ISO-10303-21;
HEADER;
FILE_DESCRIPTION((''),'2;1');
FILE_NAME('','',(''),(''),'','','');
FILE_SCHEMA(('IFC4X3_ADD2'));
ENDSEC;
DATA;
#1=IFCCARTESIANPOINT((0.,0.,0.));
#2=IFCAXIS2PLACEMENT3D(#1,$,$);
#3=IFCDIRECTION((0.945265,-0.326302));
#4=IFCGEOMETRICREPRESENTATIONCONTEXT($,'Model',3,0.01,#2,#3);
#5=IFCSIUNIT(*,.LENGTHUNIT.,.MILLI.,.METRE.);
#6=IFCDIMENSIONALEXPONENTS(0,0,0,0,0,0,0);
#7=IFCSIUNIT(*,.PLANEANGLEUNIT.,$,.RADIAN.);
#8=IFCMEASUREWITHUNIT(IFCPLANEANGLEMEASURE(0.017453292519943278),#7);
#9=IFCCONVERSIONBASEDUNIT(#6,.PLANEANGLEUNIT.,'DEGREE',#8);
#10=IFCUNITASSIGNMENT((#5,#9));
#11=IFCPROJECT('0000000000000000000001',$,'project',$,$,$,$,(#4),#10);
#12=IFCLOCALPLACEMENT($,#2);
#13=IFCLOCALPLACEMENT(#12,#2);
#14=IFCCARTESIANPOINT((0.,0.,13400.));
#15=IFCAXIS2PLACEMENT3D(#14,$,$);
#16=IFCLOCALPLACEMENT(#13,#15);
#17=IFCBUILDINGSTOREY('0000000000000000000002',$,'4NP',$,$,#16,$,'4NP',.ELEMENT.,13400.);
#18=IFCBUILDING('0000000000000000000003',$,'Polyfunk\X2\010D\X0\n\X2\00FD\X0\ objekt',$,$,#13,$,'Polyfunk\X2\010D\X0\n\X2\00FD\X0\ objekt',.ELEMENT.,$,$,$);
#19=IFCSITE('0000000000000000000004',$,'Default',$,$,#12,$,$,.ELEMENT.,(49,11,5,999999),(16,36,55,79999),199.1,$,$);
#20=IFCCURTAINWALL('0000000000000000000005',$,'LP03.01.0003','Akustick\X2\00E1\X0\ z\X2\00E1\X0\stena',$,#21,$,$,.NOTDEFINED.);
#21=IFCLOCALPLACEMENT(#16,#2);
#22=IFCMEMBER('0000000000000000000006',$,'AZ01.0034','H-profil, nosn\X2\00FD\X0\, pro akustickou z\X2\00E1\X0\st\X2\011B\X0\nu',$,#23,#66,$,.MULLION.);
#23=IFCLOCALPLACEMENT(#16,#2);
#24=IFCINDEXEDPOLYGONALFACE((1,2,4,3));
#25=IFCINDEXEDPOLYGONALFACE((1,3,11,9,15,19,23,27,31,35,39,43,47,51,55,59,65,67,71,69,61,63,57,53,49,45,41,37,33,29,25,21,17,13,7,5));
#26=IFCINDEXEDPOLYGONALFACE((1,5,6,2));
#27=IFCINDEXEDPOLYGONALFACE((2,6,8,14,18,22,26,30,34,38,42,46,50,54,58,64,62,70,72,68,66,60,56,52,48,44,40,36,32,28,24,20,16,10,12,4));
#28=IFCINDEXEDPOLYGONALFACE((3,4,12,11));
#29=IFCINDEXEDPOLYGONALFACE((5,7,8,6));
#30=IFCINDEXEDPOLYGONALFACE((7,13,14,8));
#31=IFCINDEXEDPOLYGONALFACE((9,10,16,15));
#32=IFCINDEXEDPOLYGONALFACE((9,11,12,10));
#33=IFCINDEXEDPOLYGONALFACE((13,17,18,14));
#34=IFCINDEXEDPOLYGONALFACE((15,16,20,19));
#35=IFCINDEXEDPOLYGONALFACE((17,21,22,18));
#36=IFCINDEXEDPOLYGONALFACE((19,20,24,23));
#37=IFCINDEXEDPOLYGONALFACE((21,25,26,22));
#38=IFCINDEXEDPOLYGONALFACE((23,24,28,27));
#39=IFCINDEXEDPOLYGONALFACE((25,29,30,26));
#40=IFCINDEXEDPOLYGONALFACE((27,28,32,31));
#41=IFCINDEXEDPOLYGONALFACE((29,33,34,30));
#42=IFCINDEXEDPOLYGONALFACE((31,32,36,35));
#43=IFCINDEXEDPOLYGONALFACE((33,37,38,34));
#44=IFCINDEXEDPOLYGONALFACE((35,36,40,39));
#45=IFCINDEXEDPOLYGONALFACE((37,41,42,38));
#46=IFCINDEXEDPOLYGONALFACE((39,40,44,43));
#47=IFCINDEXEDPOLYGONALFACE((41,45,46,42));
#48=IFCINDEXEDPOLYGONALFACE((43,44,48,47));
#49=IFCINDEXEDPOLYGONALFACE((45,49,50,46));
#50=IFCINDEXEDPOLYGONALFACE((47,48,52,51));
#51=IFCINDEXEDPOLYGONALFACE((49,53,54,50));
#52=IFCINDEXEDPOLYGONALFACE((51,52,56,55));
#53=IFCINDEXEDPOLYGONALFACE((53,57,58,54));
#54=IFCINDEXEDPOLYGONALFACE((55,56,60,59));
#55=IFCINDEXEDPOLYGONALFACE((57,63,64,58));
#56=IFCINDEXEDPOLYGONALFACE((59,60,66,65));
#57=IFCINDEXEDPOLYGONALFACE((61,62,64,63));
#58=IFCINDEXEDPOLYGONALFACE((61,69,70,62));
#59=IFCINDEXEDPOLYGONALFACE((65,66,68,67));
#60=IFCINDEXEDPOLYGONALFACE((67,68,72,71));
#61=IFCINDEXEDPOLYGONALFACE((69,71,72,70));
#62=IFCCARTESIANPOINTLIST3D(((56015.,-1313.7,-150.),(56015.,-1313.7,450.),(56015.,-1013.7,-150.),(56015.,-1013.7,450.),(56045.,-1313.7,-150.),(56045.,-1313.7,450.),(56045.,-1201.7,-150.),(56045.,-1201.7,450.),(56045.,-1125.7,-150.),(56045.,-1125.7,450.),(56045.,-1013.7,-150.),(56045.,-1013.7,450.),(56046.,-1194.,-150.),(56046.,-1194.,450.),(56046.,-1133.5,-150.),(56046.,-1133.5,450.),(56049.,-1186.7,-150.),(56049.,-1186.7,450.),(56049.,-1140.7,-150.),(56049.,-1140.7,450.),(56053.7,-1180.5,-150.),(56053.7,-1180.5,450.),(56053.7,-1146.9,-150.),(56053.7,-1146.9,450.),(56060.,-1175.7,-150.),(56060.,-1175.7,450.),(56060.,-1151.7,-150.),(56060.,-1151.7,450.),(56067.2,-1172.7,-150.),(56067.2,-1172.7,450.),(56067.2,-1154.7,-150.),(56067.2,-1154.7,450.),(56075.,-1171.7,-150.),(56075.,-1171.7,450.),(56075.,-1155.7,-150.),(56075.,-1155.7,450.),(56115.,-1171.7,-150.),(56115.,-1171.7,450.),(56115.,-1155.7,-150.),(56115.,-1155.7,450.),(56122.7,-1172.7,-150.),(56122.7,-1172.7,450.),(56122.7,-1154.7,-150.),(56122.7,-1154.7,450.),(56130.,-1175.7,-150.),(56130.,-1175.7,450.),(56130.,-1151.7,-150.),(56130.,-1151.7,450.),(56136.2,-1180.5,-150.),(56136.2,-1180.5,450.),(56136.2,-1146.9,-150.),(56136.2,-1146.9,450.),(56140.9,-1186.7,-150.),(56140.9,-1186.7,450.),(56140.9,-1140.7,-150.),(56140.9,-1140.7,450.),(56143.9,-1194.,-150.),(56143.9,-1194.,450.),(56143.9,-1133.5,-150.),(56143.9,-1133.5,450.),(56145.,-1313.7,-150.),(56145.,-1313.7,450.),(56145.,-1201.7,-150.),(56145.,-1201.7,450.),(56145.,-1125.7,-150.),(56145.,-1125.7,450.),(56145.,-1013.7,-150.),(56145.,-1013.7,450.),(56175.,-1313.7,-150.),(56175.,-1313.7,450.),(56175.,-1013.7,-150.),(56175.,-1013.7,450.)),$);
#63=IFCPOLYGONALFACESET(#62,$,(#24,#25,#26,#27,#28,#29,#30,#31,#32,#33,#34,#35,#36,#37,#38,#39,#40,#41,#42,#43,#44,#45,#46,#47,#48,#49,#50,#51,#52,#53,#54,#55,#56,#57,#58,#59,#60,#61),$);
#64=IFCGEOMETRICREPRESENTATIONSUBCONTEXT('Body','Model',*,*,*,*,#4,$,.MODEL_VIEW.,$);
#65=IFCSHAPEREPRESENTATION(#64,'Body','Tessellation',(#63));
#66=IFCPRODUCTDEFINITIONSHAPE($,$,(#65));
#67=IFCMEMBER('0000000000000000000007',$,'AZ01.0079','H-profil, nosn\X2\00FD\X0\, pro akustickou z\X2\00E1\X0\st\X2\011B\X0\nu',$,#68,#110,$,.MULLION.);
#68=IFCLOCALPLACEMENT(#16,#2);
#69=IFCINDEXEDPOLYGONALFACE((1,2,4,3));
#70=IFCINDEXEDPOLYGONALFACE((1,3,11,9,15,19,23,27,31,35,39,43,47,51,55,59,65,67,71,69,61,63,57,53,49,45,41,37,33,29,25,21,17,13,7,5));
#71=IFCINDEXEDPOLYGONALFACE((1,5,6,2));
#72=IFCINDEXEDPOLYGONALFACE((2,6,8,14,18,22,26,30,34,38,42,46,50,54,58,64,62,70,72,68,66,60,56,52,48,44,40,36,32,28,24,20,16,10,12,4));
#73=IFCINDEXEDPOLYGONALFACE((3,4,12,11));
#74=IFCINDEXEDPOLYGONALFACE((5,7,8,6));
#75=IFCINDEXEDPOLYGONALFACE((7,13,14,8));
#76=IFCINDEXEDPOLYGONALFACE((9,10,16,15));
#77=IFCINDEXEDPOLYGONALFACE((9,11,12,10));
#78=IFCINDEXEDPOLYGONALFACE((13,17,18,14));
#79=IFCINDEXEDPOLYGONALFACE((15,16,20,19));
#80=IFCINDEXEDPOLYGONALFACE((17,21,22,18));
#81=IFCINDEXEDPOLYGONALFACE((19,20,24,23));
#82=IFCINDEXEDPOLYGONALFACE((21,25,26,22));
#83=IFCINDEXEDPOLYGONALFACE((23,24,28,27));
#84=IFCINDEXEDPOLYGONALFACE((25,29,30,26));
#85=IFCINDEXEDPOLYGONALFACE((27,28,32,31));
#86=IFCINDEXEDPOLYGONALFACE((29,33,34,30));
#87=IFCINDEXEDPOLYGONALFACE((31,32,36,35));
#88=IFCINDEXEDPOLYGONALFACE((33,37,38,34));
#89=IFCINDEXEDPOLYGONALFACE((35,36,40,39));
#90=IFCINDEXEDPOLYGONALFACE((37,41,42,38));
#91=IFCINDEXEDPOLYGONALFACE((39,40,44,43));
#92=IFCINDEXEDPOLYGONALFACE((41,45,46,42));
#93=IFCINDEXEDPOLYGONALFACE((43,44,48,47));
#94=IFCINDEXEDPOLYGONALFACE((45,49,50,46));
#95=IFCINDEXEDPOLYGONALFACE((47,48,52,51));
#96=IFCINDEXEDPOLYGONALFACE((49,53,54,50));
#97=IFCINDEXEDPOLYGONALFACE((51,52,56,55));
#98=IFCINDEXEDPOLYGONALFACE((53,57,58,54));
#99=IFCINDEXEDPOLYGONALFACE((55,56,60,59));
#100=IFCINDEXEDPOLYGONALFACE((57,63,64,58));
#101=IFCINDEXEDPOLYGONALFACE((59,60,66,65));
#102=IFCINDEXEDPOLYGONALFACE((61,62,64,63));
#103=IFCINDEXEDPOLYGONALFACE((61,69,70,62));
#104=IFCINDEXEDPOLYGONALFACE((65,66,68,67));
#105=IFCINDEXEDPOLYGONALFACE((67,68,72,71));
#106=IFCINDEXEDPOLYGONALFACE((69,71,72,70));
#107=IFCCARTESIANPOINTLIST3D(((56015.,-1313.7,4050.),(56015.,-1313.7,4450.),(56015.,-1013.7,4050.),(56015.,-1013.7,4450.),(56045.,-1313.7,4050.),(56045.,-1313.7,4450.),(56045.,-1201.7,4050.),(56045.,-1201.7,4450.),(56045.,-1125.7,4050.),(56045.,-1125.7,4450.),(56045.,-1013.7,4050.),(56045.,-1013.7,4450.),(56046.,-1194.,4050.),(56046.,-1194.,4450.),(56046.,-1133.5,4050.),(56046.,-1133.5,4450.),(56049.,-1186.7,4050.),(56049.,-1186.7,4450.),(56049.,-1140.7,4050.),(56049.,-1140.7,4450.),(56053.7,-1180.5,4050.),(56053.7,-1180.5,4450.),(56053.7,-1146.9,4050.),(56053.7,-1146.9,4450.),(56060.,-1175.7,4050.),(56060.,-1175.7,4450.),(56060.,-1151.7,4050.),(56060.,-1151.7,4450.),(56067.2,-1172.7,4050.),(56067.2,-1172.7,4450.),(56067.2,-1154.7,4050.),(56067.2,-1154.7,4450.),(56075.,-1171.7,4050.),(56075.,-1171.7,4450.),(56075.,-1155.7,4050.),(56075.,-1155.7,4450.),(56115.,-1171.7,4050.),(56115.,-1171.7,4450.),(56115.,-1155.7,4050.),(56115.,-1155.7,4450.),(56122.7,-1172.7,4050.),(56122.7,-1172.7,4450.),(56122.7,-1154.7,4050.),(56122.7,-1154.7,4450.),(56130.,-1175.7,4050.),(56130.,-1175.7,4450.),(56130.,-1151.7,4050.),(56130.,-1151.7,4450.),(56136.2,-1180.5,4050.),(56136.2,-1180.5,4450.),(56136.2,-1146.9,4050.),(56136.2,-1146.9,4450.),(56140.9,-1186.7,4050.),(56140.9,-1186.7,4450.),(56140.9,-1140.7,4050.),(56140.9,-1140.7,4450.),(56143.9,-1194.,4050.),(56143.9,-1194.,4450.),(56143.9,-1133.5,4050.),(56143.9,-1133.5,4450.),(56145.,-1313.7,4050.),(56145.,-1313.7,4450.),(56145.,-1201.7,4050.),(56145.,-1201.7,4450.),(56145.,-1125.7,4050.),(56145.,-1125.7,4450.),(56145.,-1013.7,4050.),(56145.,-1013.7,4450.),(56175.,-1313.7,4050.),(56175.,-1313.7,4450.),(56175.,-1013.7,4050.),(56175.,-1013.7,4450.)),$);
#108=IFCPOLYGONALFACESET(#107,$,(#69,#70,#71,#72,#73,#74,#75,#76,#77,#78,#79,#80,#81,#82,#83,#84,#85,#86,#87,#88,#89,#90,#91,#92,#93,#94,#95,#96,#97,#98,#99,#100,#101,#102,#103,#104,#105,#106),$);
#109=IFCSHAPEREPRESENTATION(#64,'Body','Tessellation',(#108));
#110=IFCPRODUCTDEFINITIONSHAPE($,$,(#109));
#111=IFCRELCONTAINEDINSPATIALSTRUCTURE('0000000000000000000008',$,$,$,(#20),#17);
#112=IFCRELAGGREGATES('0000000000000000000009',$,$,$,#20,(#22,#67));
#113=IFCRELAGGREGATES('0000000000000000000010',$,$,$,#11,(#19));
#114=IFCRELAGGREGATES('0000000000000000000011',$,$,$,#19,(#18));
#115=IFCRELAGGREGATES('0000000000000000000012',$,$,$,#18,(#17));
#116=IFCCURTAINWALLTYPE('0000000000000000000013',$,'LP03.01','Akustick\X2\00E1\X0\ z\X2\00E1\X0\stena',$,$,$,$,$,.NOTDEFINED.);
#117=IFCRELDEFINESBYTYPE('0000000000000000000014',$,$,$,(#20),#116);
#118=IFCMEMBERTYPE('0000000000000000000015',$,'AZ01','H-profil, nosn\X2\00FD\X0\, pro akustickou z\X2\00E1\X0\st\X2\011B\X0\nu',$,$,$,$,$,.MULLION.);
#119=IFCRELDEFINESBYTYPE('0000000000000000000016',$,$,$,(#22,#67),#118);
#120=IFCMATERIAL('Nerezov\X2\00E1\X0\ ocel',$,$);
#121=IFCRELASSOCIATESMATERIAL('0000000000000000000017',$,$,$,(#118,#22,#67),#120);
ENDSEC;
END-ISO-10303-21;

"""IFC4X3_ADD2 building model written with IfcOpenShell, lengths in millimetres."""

from ifc_helpers import new_model, entity, si_unit, converted_unit, direction, frame, frame_2d, origin, place, context, subcontext, project, spatial, polyline, circle_curve, parameter, trimmed, segment, composite_curve, outline, extrude, source, transform, mapped, material, material_profile, profile_set, profile_usage, type_object, element, aggregate, save


model = new_model("IFC4X3_ADD2")

# Units and contexts
model_context = context("Model", 3, precision=0.01, world=origin(), true_north=direction((0.945265, -0.326302)))
body_context = subcontext(model_context, "Body", "Model", "MODEL_VIEW")
ifc_project = project(units=[si_unit("LENGTHUNIT", "METRE", prefix="MILLI"), converted_unit("PLANEANGLEUNIT", "DEGREE", entity("IfcPlaneAngleMeasure", 0.017453292519943278), si_unit("PLANEANGLEUNIT", "RADIAN"), dimensions=[0, 0, 0, 0, 0, 0, 0])], contexts=[model_context])

# Site, building, storey
site_placement = place(None, origin())
site = spatial("IfcSite", under=ifc_project, at=site_placement, Name="Default", CompositionType="ELEMENT", RefLatitude=(49, 11, 5, 999999), RefLongitude=(16, 36, 55, 79999), RefElevation=199.1)
building_placement = place(site_placement, origin())
building = spatial("IfcBuilding", under=site, at=building_placement, Name="Polyfunkčný objekt", LongName="Polyfunkčný objekt", CompositionType="ELEMENT")
storey_placement = place(building_placement, frame((0.0, 0.0, 13400.0)))
storey = spatial("IfcBuildingStorey", under=building, at=storey_placement, Name="4NP", LongName="4NP", CompositionType="ELEMENT", Elevation=13400.0)

# Curtain wall, members
curtain_wall_type = type_object("IfcCurtainWallType", Name="LP03.01", Description="Akustická zástena", PredefinedType="NOTDEFINED")
curtain_wall_1_placement = place(storey_placement, frame((0.0, 0.0, -13400.0)))
curtain_wall_1 = element("IfcCurtainWall", 1, at=curtain_wall_1_placement, inside=storey, type_object=curtain_wall_type, Name="LP03.01.0003", Description="Akustická zástena", PredefinedType="NOTDEFINED")
ifc_material_1 = material(Name="Nerezová ocel")
ifc_material_profile = material_profile(ifc_material_1, outline(composite_curve([segment(polyline([(50.0, -150.0), (80.0, -150.0)]), True, "CONTINUOUS"), segment(polyline([(80.0, -150.0), (80.0, 150.0)]), True, "CONTINUOUS"), segment(polyline([(80.0, 150.0), (50.0, 150.0)]), True, "CONTINUOUS"), segment(polyline([(50.0, 150.0), (50.0, 38.0)]), True, "CONTINUOUS"), segment(trimmed(circle_curve(frame_2d((20.0, 38.0), x_axis=(0.0, 1.0)), 30.0), [parameter(180.0)], [parameter(270.0)], True, "PARAMETER"), False, "CONTINUOUS"), segment(polyline([(20.0, 8.0), (-20.0, 8.0)]), True, "CONTINUOUS"), segment(trimmed(circle_curve(frame_2d((-20.0, 38.0), x_axis=(0.0, 1.0)), 30.0), [parameter(90.0)], [parameter(180.0)], True, "PARAMETER"), False, "CONTINUOUS"), segment(polyline([(-50.0, 38.0), (-50.0, 150.0)]), True, "CONTINUOUS"), segment(polyline([(-50.0, 150.0), (-80.0, 150.0)]), True, "CONTINUOUS"), segment(polyline([(-80.0, 150.0), (-80.0, -150.0)]), True, "CONTINUOUS"), segment(polyline([(-80.0, -150.0), (-50.0, -150.0)]), True, "CONTINUOUS"), segment(polyline([(-50.0, -150.0), (-50.0, -38.0)]), True, "CONTINUOUS"), segment(trimmed(circle_curve(frame_2d((-20.0, -38.0), x_axis=(0.0, 1.0)), 30.0), [parameter(0.0)], [parameter(90.0)], True, "PARAMETER"), False, "CONTINUOUS"), segment(polyline([(-20.0, -8.0), (20.0, -8.0)]), True, "CONTINUOUS"), segment(trimmed(circle_curve(frame_2d((20.0, -38.0), x_axis=(0.0, 1.0)), 30.0), [parameter(270.0)], [parameter(0.0)], True, "PARAMETER"), False, "CONTINUOUS"), segment(polyline([(50.0, -38.0), (50.0, -150.0)]), True, "CONTINUOUS")], self_intersect=False)), Name="Profil zástena")
ifc_profile_set = profile_set([ifc_material_profile], Name="Profil zástena")
ifc_profile_usage = profile_usage(ifc_profile_set)
member_type = type_object("IfcMemberType", Name="AZ01", Description="H-profil, nosný, pro akustickou zástěnu", PredefinedType="MULLION", material=ifc_profile_set)
shared_shape_1 = source(origin(), body_context, "Body", "SweptSolid", [
    extrude(outline(composite_curve([segment(polyline([(50.0, -150.0), (80.0, -150.0)]), True, "CONTINUOUS"), segment(polyline([(80.0, -150.0), (80.0, 150.0)]), True, "CONTINUOUS"), segment(polyline([(80.0, 150.0), (50.0, 150.0)]), True, "CONTINUOUS"), segment(polyline([(50.0, 150.0), (50.0, 38.0)]), True, "CONTINUOUS"), segment(trimmed(circle_curve(frame_2d((20.0, 38.0), x_axis=(0.0, 1.0)), 30.0), [parameter(180.0)], [parameter(270.0)], True, "PARAMETER"), False, "CONTINUOUS"), segment(polyline([(20.0, 8.0), (-20.0, 8.0)]), True, "CONTINUOUS"), segment(trimmed(circle_curve(frame_2d((-20.0, 38.0), x_axis=(0.0, 1.0)), 30.0), [parameter(90.0)], [parameter(180.0)], True, "PARAMETER"), False, "CONTINUOUS"), segment(polyline([(-50.0, 38.0), (-50.0, 150.0)]), True, "CONTINUOUS"), segment(polyline([(-50.0, 150.0), (-80.0, 150.0)]), True, "CONTINUOUS"), segment(polyline([(-80.0, 150.0), (-80.0, -150.0)]), True, "CONTINUOUS"), segment(polyline([(-80.0, -150.0), (-50.0, -150.0)]), True, "CONTINUOUS"), segment(polyline([(-50.0, -150.0), (-50.0, -38.0)]), True, "CONTINUOUS"), segment(trimmed(circle_curve(frame_2d((-20.0, -38.0), x_axis=(0.0, 1.0)), 30.0), [parameter(0.0)], [parameter(90.0)], True, "PARAMETER"), False, "CONTINUOUS"), segment(polyline([(-20.0, -8.0), (20.0, -8.0)]), True, "CONTINUOUS"), segment(trimmed(circle_curve(frame_2d((20.0, -38.0), x_axis=(0.0, 1.0)), 30.0), [parameter(270.0)], [parameter(0.0)], True, "PARAMETER"), False, "CONTINUOUS"), segment(polyline([(50.0, -38.0), (50.0, -150.0)]), True, "CONTINUOUS")], self_intersect=False)), frame((-150.0, 0.0, -600.0), z_axis=(0.0, 0.0, 1.0), x_axis=(0.0, 1.0, 0.0)), (0.0, 0.0, 1.0), 600.0),
])
member_1_placement = place(curtain_wall_1_placement, frame((56095.0, -1313.7, 13850.0), z_axis=(0.0, 0.0, 1.0), x_axis=(0.0, -1.0, 0.0)))
member_1 = element("IfcMember", 2, at=member_1_placement, type_object=member_type, material=ifc_profile_usage, Name="AZ01.0034", Description="H-profil, nosný, pro akustickou zástěnu", PredefinedType="MULLION", context=body_context, shape_type="MappedRepresentation", body=[
    mapped(shared_shape_1, transform((0.0, 0.0, 0.0), scale=1.0)),
])
shared_shape_2 = source(origin(), body_context, "Body", "SweptSolid", [
    extrude(outline(composite_curve([segment(polyline([(50.0, -150.0), (80.0, -150.0)]), True, "CONTINUOUS"), segment(polyline([(80.0, -150.0), (80.0, 150.0)]), True, "CONTINUOUS"), segment(polyline([(80.0, 150.0), (50.0, 150.0)]), True, "CONTINUOUS"), segment(polyline([(50.0, 150.0), (50.0, 38.0)]), True, "CONTINUOUS"), segment(trimmed(circle_curve(frame_2d((20.0, 38.0), x_axis=(0.0, 1.0)), 30.0), [parameter(180.0)], [parameter(270.0)], True, "PARAMETER"), False, "CONTINUOUS"), segment(polyline([(20.0, 8.0), (-20.0, 8.0)]), True, "CONTINUOUS"), segment(trimmed(circle_curve(frame_2d((-20.0, 38.0), x_axis=(0.0, 1.0)), 30.0), [parameter(90.0)], [parameter(180.0)], True, "PARAMETER"), False, "CONTINUOUS"), segment(polyline([(-50.0, 38.0), (-50.0, 150.0)]), True, "CONTINUOUS"), segment(polyline([(-50.0, 150.0), (-80.0, 150.0)]), True, "CONTINUOUS"), segment(polyline([(-80.0, 150.0), (-80.0, -150.0)]), True, "CONTINUOUS"), segment(polyline([(-80.0, -150.0), (-50.0, -150.0)]), True, "CONTINUOUS"), segment(polyline([(-50.0, -150.0), (-50.0, -38.0)]), True, "CONTINUOUS"), segment(trimmed(circle_curve(frame_2d((-20.0, -38.0), x_axis=(0.0, 1.0)), 30.0), [parameter(0.0)], [parameter(90.0)], True, "PARAMETER"), False, "CONTINUOUS"), segment(polyline([(-20.0, -8.0), (20.0, -8.0)]), True, "CONTINUOUS"), segment(trimmed(circle_curve(frame_2d((20.0, -38.0), x_axis=(0.0, 1.0)), 30.0), [parameter(270.0)], [parameter(0.0)], True, "PARAMETER"), False, "CONTINUOUS"), segment(polyline([(50.0, -38.0), (50.0, -150.0)]), True, "CONTINUOUS")], self_intersect=False)), frame((-150.0, 0.0, -400.0), z_axis=(0.0, 0.0, 1.0), x_axis=(0.0, 1.0, 0.0)), (0.0, 0.0, 1.0), 400.0),
])
member_2_placement = place(curtain_wall_1_placement, frame((56095.0, -1313.7, 17850.0), z_axis=(0.0, 0.0, 1.0), x_axis=(0.0, -1.0, 0.0)))
member_2 = element("IfcMember", 3, at=member_2_placement, type_object=member_type, material=ifc_profile_usage, Name="AZ01.0079", Description="H-profil, nosný, pro akustickou zástěnu", PredefinedType="MULLION", context=body_context, shape_type="MappedRepresentation", body=[
    mapped(shared_shape_2, transform((0.0, 0.0, 0.0), scale=1.0)),
])

aggregate(curtain_wall_1, [member_1, member_2])

save(model, "model.ifc")
